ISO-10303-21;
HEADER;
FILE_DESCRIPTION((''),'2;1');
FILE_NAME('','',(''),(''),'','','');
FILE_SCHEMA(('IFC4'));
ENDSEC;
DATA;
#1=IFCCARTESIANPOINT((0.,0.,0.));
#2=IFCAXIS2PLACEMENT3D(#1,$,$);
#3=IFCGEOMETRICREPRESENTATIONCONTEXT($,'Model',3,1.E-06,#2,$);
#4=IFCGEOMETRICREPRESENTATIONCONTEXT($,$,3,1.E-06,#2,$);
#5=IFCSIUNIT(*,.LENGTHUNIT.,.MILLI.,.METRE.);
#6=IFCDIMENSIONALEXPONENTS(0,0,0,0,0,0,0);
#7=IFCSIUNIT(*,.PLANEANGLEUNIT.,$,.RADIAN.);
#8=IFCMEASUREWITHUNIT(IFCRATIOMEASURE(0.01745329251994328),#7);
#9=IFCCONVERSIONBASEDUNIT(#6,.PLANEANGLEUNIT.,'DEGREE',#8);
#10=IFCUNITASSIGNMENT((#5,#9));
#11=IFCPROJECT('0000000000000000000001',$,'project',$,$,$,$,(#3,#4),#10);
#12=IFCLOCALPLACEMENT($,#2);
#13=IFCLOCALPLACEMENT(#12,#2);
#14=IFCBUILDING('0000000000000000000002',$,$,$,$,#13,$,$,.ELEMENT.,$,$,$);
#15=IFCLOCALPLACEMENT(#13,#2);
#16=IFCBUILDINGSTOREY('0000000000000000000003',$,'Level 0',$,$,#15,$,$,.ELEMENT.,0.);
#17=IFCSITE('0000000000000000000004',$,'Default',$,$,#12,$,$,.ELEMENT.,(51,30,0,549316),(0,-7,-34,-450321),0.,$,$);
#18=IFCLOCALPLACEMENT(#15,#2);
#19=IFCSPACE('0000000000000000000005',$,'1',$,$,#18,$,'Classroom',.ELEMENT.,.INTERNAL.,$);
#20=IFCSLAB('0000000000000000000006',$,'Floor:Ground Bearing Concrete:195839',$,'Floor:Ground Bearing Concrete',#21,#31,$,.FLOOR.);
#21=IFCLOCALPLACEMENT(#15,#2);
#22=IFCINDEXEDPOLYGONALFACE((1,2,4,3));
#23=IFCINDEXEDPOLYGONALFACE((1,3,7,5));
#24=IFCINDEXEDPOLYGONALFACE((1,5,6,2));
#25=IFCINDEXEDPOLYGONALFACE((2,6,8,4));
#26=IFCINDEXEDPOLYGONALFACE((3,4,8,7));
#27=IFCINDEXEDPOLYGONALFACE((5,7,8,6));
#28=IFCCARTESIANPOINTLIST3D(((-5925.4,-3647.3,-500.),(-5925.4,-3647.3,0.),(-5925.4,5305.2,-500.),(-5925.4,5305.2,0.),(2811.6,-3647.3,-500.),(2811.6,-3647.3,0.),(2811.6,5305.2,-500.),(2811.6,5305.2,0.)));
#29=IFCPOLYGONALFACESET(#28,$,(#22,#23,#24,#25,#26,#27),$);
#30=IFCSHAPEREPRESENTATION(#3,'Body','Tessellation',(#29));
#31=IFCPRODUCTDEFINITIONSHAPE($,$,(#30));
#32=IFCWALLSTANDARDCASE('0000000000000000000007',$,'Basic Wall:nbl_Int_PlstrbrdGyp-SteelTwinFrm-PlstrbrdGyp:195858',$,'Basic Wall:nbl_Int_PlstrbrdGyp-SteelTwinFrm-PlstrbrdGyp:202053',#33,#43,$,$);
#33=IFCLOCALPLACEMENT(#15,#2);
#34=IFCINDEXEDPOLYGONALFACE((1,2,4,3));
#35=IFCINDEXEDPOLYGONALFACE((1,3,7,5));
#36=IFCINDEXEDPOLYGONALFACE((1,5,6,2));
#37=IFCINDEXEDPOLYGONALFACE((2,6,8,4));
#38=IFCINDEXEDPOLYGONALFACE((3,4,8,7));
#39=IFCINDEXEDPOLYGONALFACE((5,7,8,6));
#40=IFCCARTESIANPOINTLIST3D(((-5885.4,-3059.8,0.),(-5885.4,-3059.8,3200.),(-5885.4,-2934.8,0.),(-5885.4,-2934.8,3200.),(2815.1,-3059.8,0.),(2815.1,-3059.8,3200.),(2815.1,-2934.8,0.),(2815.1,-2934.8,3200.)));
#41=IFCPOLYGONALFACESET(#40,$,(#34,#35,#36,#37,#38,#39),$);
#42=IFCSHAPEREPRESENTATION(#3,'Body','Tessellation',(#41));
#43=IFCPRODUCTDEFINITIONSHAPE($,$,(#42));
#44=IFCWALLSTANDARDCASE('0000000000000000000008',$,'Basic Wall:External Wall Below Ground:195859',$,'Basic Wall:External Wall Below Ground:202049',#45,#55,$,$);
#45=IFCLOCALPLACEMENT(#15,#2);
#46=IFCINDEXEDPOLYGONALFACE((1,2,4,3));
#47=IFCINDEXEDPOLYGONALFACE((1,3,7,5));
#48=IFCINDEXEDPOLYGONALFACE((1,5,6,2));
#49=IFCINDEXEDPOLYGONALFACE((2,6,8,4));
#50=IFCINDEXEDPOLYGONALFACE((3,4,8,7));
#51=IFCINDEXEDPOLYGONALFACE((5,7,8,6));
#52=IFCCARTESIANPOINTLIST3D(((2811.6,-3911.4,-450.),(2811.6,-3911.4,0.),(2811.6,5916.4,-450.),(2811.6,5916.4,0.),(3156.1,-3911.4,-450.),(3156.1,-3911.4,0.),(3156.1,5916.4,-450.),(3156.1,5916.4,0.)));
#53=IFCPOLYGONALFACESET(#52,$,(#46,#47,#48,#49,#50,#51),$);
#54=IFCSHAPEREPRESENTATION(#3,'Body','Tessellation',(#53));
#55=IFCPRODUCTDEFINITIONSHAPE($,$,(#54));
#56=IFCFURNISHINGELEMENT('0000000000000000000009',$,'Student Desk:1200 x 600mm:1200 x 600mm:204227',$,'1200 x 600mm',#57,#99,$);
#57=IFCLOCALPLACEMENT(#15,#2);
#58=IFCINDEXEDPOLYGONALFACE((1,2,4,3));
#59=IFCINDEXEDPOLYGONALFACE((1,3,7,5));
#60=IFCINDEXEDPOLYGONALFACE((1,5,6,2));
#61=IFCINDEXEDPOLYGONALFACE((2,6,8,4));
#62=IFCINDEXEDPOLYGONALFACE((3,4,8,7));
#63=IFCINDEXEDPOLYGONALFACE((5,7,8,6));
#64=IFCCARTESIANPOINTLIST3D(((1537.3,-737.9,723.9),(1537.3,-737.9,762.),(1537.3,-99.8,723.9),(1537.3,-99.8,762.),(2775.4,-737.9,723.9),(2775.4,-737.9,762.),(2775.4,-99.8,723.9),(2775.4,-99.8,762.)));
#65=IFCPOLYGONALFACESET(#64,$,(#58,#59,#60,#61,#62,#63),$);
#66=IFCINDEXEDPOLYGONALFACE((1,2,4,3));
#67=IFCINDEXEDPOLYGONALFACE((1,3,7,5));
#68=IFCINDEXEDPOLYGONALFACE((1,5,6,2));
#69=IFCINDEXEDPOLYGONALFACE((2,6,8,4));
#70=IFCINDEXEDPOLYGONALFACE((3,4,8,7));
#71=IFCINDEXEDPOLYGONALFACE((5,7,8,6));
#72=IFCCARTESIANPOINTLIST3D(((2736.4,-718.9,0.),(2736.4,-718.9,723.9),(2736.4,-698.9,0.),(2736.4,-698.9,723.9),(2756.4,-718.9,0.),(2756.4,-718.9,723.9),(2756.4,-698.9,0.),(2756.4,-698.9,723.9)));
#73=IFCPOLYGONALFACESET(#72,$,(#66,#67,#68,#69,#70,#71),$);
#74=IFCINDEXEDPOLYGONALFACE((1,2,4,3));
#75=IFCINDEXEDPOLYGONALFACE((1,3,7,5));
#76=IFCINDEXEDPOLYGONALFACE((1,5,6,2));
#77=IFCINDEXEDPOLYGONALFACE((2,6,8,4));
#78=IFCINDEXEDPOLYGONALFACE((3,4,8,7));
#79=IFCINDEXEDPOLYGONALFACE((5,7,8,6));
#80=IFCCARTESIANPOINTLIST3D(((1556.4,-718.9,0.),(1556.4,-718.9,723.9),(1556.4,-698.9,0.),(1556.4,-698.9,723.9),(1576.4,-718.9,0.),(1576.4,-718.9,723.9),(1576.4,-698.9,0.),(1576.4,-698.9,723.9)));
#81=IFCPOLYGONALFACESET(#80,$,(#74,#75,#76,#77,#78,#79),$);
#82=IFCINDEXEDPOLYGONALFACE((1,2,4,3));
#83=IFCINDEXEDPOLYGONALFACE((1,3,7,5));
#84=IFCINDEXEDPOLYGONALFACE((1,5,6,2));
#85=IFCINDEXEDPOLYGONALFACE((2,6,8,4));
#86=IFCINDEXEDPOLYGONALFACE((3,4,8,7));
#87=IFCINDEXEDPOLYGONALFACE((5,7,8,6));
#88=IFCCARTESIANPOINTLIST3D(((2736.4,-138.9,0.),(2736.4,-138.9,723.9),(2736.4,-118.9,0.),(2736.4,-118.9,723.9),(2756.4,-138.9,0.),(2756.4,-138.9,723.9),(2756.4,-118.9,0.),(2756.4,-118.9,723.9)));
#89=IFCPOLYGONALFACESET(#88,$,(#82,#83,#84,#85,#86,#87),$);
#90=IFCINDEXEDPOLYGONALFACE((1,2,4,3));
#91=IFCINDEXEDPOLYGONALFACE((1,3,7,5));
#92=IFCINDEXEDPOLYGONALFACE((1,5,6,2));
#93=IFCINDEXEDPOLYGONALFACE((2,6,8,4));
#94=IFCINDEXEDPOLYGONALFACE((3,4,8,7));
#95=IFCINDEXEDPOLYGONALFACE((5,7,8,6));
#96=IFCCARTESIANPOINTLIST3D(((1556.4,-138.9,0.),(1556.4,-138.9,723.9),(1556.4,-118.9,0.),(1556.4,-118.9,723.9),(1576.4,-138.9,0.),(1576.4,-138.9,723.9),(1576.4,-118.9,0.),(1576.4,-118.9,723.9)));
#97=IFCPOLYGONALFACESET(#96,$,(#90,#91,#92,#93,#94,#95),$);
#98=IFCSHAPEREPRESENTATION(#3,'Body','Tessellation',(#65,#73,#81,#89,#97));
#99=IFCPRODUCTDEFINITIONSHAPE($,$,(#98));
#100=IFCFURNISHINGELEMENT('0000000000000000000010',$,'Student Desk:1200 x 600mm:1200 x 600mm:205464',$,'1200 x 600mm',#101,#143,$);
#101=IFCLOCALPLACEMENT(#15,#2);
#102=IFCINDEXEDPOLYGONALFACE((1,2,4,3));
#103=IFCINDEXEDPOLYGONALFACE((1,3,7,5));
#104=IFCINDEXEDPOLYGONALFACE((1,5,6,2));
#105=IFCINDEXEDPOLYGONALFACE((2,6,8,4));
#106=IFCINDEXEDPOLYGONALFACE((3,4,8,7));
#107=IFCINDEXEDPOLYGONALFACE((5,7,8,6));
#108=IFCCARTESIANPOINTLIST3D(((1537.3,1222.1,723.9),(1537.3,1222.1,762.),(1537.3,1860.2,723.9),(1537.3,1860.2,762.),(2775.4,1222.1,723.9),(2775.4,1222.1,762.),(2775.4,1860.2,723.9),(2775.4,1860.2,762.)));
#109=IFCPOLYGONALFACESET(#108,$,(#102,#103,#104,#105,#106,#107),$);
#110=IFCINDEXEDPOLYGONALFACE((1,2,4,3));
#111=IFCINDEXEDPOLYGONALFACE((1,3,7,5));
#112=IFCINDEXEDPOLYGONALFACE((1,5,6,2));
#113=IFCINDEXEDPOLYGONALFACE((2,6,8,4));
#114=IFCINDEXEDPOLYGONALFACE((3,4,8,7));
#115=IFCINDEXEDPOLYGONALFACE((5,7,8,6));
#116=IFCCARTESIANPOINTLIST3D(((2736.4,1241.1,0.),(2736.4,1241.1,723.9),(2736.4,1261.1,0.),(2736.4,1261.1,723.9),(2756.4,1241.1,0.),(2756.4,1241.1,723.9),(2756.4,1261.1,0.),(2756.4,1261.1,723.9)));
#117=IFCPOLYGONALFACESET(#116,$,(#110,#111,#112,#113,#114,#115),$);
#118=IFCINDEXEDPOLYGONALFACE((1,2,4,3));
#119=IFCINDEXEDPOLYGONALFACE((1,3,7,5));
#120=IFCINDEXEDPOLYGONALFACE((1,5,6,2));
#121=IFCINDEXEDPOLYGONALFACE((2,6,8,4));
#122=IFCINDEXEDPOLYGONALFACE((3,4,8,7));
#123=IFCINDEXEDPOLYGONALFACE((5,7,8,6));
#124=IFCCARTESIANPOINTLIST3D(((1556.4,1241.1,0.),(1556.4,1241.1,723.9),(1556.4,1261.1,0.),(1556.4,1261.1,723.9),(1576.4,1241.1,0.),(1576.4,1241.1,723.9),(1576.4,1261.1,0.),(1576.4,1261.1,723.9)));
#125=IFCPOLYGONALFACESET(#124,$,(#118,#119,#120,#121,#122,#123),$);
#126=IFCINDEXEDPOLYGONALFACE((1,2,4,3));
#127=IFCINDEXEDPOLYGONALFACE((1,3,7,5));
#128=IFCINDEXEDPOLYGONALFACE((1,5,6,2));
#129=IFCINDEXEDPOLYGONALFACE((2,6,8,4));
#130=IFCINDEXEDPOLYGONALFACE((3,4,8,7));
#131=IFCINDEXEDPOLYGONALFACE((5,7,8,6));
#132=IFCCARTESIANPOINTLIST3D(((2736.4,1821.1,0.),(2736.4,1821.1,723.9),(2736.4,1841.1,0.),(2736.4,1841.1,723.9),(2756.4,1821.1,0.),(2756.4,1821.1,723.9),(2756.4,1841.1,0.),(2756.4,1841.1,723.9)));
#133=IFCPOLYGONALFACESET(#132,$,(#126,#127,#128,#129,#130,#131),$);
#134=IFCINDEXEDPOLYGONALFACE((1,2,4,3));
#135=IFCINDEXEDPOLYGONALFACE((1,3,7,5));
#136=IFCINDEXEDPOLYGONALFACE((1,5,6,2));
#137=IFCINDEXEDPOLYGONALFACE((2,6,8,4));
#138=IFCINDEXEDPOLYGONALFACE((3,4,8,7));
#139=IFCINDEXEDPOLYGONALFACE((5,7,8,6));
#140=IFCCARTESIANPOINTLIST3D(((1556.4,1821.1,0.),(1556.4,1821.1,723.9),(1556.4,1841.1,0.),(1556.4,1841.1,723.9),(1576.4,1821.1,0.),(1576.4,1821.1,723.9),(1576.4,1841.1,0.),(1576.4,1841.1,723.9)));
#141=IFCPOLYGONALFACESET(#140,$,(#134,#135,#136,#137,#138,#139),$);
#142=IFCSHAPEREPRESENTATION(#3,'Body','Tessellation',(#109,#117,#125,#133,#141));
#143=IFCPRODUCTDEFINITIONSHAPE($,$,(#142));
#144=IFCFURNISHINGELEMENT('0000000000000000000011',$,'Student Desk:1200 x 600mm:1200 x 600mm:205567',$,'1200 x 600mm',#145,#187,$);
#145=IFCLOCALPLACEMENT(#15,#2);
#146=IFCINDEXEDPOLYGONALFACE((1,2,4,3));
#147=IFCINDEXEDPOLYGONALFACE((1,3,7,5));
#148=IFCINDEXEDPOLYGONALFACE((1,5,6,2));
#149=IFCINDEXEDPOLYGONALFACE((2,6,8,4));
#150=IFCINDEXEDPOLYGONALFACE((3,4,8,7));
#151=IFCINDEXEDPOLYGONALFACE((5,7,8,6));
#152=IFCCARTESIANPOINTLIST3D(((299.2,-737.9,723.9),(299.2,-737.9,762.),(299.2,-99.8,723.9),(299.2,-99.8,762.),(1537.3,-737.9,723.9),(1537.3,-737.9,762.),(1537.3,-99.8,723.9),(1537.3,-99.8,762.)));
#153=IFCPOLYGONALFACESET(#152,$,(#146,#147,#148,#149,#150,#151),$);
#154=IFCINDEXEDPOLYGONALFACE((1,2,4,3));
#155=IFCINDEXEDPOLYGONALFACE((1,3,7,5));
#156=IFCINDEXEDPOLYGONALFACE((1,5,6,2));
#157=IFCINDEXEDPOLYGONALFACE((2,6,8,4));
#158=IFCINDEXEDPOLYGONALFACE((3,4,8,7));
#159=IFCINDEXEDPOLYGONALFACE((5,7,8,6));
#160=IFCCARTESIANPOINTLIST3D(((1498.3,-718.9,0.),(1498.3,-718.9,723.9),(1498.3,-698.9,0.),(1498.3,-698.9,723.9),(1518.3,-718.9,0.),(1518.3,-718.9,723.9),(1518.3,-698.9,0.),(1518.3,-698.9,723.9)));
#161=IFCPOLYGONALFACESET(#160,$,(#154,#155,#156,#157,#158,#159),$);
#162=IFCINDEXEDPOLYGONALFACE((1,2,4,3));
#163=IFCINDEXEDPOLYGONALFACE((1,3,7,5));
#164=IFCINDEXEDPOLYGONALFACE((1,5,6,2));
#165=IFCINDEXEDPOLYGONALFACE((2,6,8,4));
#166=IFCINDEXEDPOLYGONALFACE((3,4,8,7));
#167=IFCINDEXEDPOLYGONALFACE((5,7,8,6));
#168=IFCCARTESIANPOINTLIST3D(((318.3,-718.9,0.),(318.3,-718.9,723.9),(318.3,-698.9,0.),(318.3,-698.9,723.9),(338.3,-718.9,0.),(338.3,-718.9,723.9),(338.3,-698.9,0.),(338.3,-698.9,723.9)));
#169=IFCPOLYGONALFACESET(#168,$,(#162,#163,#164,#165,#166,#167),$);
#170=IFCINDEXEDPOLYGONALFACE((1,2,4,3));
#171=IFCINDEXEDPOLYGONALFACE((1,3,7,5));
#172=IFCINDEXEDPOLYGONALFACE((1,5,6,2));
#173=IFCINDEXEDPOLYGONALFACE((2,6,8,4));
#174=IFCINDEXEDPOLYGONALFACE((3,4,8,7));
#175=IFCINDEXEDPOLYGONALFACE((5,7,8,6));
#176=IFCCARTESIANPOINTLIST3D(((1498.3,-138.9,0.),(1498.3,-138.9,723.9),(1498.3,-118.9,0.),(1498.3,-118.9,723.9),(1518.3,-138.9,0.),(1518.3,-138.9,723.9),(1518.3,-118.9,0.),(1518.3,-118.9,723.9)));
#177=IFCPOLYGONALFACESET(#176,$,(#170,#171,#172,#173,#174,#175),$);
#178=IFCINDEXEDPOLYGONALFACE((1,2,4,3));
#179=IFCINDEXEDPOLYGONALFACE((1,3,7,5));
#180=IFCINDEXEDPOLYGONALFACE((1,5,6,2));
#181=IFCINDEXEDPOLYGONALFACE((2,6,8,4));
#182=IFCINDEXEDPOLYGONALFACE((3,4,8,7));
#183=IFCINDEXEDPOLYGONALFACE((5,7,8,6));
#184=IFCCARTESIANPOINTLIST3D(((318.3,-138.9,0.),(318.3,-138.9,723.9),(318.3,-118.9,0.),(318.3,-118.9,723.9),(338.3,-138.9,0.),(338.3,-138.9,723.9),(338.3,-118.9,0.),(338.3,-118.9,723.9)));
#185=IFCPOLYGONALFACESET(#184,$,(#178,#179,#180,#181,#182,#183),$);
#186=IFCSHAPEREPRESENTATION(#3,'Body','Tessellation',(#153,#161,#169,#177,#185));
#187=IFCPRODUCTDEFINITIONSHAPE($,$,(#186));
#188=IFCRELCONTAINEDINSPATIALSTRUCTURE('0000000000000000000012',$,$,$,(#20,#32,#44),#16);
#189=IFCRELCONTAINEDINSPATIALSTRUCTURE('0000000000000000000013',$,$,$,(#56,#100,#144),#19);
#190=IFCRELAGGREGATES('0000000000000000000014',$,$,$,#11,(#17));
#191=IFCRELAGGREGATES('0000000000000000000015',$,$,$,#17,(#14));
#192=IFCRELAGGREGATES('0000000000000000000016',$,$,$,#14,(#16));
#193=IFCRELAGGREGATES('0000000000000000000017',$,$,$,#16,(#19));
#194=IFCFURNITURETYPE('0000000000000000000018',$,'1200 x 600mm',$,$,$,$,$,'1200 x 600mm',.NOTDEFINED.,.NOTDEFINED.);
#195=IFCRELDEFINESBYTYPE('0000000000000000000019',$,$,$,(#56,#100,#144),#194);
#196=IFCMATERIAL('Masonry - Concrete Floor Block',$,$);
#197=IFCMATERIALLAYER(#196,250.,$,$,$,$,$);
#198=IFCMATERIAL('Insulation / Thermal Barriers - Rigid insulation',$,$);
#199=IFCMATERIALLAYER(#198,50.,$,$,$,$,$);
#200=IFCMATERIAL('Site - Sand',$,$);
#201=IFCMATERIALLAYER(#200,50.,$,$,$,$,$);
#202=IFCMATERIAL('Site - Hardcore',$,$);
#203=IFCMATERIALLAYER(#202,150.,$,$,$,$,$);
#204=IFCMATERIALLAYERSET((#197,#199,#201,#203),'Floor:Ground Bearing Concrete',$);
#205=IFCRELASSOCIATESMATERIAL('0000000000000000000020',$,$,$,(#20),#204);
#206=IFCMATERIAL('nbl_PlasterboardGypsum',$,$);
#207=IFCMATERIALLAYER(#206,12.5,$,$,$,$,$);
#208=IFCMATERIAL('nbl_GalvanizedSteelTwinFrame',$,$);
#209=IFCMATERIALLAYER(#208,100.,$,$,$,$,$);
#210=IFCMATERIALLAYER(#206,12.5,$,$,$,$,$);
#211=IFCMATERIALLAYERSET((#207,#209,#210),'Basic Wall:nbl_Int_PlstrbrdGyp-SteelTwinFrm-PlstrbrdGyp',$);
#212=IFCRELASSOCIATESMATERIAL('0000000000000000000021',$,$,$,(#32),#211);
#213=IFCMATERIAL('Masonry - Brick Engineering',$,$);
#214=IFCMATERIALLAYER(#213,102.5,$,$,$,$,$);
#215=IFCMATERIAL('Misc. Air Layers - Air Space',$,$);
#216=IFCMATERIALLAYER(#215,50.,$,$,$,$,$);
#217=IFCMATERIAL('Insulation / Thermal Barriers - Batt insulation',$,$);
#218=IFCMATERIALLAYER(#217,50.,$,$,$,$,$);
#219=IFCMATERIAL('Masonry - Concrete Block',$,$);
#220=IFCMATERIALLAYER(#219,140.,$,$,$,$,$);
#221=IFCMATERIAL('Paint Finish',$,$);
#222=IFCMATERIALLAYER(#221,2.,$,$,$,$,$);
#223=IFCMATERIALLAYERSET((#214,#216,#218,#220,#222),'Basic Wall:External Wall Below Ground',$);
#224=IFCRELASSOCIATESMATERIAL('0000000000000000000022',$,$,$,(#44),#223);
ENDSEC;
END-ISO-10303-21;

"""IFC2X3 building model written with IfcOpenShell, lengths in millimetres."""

from ifc_helpers import new_model, entity, si_unit, converted_unit, frame, frame_2d, origin, origin_2d_with_axis, place, context, project, spatial, polyline, rectangle, extrude, clip, bounded_halfspace, source, transform, mapped, material, layer, layer_set, layer_usage, type_object, type_shapes, element, save


model = new_model("IFC2X3")

# Units and contexts
model_context = context("Model", 3, precision=1e-06, world=origin())
context_of_model = context(None, 3, precision=1e-06, world=origin())
ifc_project = project(units=[si_unit("LENGTHUNIT", "METRE", prefix="MILLI"), converted_unit("PLANEANGLEUNIT", "DEGREE", entity("IfcRatioMeasure", 0.01745329251994328), si_unit("PLANEANGLEUNIT", "RADIAN"), dimensions=[0, 0, 0, 0, 0, 0, 0])], contexts=[model_context, context_of_model])

# Site, building, storey
site_placement = place(None, origin())
site = spatial("IfcSite", under=ifc_project, at=site_placement, Name="Default", CompositionType="ELEMENT", RefLatitude=(51, 30, 0, 549316), RefLongitude=(0, -7, -34, -450321), RefElevation=0.0)
building_placement = place(site_placement, origin())
building = spatial("IfcBuilding", under=site, at=building_placement, CompositionType="ELEMENT")
storey_placement = place(building_placement, origin())
storey = spatial("IfcBuildingStorey", under=building, at=storey_placement, Name="Level 0", CompositionType="ELEMENT", Elevation=0.0)

# Slab
ifc_material_1 = material(Name="Masonry - Concrete Floor Block")
ifc_layer_1 = layer(ifc_material_1, 250.0)
ifc_material_2 = material(Name="Insulation / Thermal Barriers - Rigid insulation")
ifc_layer_2 = layer(ifc_material_2, 50.0)
ifc_material_3 = material(Name="Site - Sand")
ifc_layer_3 = layer(ifc_material_3, 50.0)
ifc_material_4 = material(Name="Site - Hardcore")
ifc_layer_4 = layer(ifc_material_4, 150.0)
ifc_layer_set_1 = layer_set([ifc_layer_1, ifc_layer_2, ifc_layer_3, ifc_layer_4], Name="Floor:Ground Bearing Concrete")
ifc_layer_usage_1 = layer_usage(ifc_layer_set_1, "AXIS3", "POSITIVE", 0.0)
slab_placement = place(storey_placement, frame((-5925.4, -3647.3, -500.0)))
element("IfcSlab", 1, at=slab_placement, inside=storey, material=ifc_layer_usage_1, Name="Floor:Ground Bearing Concrete:195839", ObjectType="Floor:Ground Bearing Concrete", PredefinedType="FLOOR", context=model_context, shape_type="SweptSolid", body=[
    extrude(rectangle(XDim=8952.5, YDim=8737.0, at=frame_2d((0.0, 0.0), x_axis=(0.0, -1.0))), frame((4368.5, 4476.3, 500.0), z_axis=(0.0, 0.0, -1.0), x_axis=(-1.0, 0.0, 0.0)), (0.0, 0.0, 1.0), 500.0),
])

# Walls
ifc_material_5 = material(Name="nbl_PlasterboardGypsum")
ifc_layer_5 = layer(ifc_material_5, 12.5)
ifc_material_6 = material(Name="nbl_GalvanizedSteelTwinFrame")
ifc_layer_6 = layer(ifc_material_6, 100.0)
ifc_layer_7 = layer(ifc_material_5, 12.5)
ifc_layer_set_2 = layer_set([ifc_layer_5, ifc_layer_6, ifc_layer_7], Name="Basic Wall:nbl_Int_PlstrbrdGyp-SteelTwinFrm-PlstrbrdGyp")
ifc_layer_usage_2 = layer_usage(ifc_layer_set_2, "AXIS2", "POSITIVE", -62.5)
wall_1_placement = place(storey_placement, frame((-5885.4, -2997.3, 0.0)))
element("IfcWallStandardCase", 2, at=wall_1_placement, inside=storey, material=ifc_layer_usage_2, Name="Basic Wall:nbl_Int_PlstrbrdGyp-SteelTwinFrm-PlstrbrdGyp:195858", ObjectType="Basic Wall:nbl_Int_PlstrbrdGyp-SteelTwinFrm-PlstrbrdGyp:202053", context=model_context, shape_type="Clipping", body=[
    clip(extrude(rectangle(XDim=8700.5, YDim=125.0, at=frame_2d((4350.3, 0.0), x_axis=(-1.0, 0.0))), origin(), (0.0, 0.0, 1.0), 3200.0), bounded_halfspace(frame((0.0, -62.5, 3200.0), z_axis=(0.0, 0.0, -1.0), x_axis=(0.0, -1.0, 0.0)), True, frame((0.0, -62.5, 3200.0)), polyline([(0.0, 0.0), (8700.5, 0.0), (8700.5, 125.0), (901.0, 125.0), (776.0, 125.0), (0.0, 125.0), (0.0, 0.0)]))),
])
ifc_material_7 = material(Name="Masonry - Brick Engineering")
ifc_layer_8 = layer(ifc_material_7, 102.5)
ifc_material_8 = material(Name="Misc. Air Layers - Air Space")
ifc_layer_9 = layer(ifc_material_8, 50.0)
ifc_material_9 = material(Name="Insulation / Thermal Barriers - Batt insulation")
ifc_layer_10 = layer(ifc_material_9, 50.0)
ifc_material_10 = material(Name="Masonry - Concrete Block")
ifc_layer_11 = layer(ifc_material_10, 140.0)
ifc_material_11 = material(Name="Paint Finish")
ifc_layer_12 = layer(ifc_material_11, 2.0)
ifc_layer_set_3 = layer_set([ifc_layer_8, ifc_layer_9, ifc_layer_10, ifc_layer_11, ifc_layer_12], Name="Basic Wall:External Wall Below Ground")
ifc_layer_usage_3 = layer_usage(ifc_layer_set_3, "AXIS2", "POSITIVE", -172.2)
wall_2_placement = place(storey_placement, frame((2983.9, -3911.4, -450.0), z_axis=(0.0, 0.0, 1.0), x_axis=(0.0, 1.0, 0.0)))
element("IfcWallStandardCase", 3, at=wall_2_placement, inside=storey, material=ifc_layer_usage_3, Name="Basic Wall:External Wall Below Ground:195859", ObjectType="Basic Wall:External Wall Below Ground:202049", context=model_context, shape_type="SweptSolid", body=[
    extrude(rectangle(XDim=9827.8, YDim=344.5, at=frame_2d((4913.9, 0.0), x_axis=(-1.0, 0.0))), origin(), (0.0, 0.0, 1.0), 450.0),
])

# Shared definitions
space_placement = place(storey_placement, origin())
space = spatial("IfcSpace", under=storey, at=space_placement, Name="1", LongName="Classroom", CompositionType="ELEMENT", InteriorOrExteriorSpace="INTERNAL")

# Furnishing elements
furniture_type = type_object("IfcFurnitureType", Name="1200 x 600mm", ElementType="1200 x 600mm", AssemblyPlace="NOTDEFINED")
shared_shape_1 = source(origin(), model_context, "Body", "SweptSolid", [
    extrude(rectangle(XDim=1238.1, YDim=638.1, at=origin_2d_with_axis()), frame((600.0, 300.0, 723.9), z_axis=(0.0, 0.0, 1.0), x_axis=(-1.0, 0.0, 0.0)), (0.0, 0.0, 1.0), 38.1),
    extrude(rectangle(XDim=20.0, YDim=20.0, at=origin_2d_with_axis()), frame((1190.0, 10.0, 0.0)), (0.0, 0.0, 1.0), 723.9),
    extrude(rectangle(XDim=20.0, YDim=20.0, at=origin_2d_with_axis()), frame((10.0, 10.0, 0.0), z_axis=(0.0, 0.0, 1.0), x_axis=(0.0, 1.0, 0.0)), (0.0, 0.0, 1.0), 723.9),
    extrude(rectangle(XDim=20.0, YDim=20.0, at=origin_2d_with_axis()), frame((1190.0, 590.0, 0.0), z_axis=(0.0, 0.0, 1.0), x_axis=(0.0, -1.0, 0.0)), (0.0, 0.0, 1.0), 723.9),
    extrude(rectangle(XDim=20.0, YDim=20.0, at=origin_2d_with_axis()), frame((10.0, 590.0, 0.0), z_axis=(0.0, 0.0, 1.0), x_axis=(-1.0, 0.0, 0.0)), (0.0, 0.0, 1.0), 723.9),
])
type_shapes(furniture_type, [shared_shape_1])
for number, where, name in (
    (4, (1556.4, -718.9, 0.0), "Student Desk:1200 x 600mm:1200 x 600mm:204227"),
    (5, (1556.4, 1241.1, 0.0), "Student Desk:1200 x 600mm:1200 x 600mm:205464"),
    (6, (318.3, -718.9, 0.0), "Student Desk:1200 x 600mm:1200 x 600mm:205567"),
):
    element("IfcFurnishingElement", number, at=place(space_placement, frame(where)), inside=space, type_object=furniture_type, Name=name, ObjectType="1200 x 600mm", context=model_context, shape_type="MappedRepresentation", body=[
        mapped(shared_shape_1, transform((0.0, 0.0, 0.0), scale=1.0)),
    ])

save(model, "model.ifc")
